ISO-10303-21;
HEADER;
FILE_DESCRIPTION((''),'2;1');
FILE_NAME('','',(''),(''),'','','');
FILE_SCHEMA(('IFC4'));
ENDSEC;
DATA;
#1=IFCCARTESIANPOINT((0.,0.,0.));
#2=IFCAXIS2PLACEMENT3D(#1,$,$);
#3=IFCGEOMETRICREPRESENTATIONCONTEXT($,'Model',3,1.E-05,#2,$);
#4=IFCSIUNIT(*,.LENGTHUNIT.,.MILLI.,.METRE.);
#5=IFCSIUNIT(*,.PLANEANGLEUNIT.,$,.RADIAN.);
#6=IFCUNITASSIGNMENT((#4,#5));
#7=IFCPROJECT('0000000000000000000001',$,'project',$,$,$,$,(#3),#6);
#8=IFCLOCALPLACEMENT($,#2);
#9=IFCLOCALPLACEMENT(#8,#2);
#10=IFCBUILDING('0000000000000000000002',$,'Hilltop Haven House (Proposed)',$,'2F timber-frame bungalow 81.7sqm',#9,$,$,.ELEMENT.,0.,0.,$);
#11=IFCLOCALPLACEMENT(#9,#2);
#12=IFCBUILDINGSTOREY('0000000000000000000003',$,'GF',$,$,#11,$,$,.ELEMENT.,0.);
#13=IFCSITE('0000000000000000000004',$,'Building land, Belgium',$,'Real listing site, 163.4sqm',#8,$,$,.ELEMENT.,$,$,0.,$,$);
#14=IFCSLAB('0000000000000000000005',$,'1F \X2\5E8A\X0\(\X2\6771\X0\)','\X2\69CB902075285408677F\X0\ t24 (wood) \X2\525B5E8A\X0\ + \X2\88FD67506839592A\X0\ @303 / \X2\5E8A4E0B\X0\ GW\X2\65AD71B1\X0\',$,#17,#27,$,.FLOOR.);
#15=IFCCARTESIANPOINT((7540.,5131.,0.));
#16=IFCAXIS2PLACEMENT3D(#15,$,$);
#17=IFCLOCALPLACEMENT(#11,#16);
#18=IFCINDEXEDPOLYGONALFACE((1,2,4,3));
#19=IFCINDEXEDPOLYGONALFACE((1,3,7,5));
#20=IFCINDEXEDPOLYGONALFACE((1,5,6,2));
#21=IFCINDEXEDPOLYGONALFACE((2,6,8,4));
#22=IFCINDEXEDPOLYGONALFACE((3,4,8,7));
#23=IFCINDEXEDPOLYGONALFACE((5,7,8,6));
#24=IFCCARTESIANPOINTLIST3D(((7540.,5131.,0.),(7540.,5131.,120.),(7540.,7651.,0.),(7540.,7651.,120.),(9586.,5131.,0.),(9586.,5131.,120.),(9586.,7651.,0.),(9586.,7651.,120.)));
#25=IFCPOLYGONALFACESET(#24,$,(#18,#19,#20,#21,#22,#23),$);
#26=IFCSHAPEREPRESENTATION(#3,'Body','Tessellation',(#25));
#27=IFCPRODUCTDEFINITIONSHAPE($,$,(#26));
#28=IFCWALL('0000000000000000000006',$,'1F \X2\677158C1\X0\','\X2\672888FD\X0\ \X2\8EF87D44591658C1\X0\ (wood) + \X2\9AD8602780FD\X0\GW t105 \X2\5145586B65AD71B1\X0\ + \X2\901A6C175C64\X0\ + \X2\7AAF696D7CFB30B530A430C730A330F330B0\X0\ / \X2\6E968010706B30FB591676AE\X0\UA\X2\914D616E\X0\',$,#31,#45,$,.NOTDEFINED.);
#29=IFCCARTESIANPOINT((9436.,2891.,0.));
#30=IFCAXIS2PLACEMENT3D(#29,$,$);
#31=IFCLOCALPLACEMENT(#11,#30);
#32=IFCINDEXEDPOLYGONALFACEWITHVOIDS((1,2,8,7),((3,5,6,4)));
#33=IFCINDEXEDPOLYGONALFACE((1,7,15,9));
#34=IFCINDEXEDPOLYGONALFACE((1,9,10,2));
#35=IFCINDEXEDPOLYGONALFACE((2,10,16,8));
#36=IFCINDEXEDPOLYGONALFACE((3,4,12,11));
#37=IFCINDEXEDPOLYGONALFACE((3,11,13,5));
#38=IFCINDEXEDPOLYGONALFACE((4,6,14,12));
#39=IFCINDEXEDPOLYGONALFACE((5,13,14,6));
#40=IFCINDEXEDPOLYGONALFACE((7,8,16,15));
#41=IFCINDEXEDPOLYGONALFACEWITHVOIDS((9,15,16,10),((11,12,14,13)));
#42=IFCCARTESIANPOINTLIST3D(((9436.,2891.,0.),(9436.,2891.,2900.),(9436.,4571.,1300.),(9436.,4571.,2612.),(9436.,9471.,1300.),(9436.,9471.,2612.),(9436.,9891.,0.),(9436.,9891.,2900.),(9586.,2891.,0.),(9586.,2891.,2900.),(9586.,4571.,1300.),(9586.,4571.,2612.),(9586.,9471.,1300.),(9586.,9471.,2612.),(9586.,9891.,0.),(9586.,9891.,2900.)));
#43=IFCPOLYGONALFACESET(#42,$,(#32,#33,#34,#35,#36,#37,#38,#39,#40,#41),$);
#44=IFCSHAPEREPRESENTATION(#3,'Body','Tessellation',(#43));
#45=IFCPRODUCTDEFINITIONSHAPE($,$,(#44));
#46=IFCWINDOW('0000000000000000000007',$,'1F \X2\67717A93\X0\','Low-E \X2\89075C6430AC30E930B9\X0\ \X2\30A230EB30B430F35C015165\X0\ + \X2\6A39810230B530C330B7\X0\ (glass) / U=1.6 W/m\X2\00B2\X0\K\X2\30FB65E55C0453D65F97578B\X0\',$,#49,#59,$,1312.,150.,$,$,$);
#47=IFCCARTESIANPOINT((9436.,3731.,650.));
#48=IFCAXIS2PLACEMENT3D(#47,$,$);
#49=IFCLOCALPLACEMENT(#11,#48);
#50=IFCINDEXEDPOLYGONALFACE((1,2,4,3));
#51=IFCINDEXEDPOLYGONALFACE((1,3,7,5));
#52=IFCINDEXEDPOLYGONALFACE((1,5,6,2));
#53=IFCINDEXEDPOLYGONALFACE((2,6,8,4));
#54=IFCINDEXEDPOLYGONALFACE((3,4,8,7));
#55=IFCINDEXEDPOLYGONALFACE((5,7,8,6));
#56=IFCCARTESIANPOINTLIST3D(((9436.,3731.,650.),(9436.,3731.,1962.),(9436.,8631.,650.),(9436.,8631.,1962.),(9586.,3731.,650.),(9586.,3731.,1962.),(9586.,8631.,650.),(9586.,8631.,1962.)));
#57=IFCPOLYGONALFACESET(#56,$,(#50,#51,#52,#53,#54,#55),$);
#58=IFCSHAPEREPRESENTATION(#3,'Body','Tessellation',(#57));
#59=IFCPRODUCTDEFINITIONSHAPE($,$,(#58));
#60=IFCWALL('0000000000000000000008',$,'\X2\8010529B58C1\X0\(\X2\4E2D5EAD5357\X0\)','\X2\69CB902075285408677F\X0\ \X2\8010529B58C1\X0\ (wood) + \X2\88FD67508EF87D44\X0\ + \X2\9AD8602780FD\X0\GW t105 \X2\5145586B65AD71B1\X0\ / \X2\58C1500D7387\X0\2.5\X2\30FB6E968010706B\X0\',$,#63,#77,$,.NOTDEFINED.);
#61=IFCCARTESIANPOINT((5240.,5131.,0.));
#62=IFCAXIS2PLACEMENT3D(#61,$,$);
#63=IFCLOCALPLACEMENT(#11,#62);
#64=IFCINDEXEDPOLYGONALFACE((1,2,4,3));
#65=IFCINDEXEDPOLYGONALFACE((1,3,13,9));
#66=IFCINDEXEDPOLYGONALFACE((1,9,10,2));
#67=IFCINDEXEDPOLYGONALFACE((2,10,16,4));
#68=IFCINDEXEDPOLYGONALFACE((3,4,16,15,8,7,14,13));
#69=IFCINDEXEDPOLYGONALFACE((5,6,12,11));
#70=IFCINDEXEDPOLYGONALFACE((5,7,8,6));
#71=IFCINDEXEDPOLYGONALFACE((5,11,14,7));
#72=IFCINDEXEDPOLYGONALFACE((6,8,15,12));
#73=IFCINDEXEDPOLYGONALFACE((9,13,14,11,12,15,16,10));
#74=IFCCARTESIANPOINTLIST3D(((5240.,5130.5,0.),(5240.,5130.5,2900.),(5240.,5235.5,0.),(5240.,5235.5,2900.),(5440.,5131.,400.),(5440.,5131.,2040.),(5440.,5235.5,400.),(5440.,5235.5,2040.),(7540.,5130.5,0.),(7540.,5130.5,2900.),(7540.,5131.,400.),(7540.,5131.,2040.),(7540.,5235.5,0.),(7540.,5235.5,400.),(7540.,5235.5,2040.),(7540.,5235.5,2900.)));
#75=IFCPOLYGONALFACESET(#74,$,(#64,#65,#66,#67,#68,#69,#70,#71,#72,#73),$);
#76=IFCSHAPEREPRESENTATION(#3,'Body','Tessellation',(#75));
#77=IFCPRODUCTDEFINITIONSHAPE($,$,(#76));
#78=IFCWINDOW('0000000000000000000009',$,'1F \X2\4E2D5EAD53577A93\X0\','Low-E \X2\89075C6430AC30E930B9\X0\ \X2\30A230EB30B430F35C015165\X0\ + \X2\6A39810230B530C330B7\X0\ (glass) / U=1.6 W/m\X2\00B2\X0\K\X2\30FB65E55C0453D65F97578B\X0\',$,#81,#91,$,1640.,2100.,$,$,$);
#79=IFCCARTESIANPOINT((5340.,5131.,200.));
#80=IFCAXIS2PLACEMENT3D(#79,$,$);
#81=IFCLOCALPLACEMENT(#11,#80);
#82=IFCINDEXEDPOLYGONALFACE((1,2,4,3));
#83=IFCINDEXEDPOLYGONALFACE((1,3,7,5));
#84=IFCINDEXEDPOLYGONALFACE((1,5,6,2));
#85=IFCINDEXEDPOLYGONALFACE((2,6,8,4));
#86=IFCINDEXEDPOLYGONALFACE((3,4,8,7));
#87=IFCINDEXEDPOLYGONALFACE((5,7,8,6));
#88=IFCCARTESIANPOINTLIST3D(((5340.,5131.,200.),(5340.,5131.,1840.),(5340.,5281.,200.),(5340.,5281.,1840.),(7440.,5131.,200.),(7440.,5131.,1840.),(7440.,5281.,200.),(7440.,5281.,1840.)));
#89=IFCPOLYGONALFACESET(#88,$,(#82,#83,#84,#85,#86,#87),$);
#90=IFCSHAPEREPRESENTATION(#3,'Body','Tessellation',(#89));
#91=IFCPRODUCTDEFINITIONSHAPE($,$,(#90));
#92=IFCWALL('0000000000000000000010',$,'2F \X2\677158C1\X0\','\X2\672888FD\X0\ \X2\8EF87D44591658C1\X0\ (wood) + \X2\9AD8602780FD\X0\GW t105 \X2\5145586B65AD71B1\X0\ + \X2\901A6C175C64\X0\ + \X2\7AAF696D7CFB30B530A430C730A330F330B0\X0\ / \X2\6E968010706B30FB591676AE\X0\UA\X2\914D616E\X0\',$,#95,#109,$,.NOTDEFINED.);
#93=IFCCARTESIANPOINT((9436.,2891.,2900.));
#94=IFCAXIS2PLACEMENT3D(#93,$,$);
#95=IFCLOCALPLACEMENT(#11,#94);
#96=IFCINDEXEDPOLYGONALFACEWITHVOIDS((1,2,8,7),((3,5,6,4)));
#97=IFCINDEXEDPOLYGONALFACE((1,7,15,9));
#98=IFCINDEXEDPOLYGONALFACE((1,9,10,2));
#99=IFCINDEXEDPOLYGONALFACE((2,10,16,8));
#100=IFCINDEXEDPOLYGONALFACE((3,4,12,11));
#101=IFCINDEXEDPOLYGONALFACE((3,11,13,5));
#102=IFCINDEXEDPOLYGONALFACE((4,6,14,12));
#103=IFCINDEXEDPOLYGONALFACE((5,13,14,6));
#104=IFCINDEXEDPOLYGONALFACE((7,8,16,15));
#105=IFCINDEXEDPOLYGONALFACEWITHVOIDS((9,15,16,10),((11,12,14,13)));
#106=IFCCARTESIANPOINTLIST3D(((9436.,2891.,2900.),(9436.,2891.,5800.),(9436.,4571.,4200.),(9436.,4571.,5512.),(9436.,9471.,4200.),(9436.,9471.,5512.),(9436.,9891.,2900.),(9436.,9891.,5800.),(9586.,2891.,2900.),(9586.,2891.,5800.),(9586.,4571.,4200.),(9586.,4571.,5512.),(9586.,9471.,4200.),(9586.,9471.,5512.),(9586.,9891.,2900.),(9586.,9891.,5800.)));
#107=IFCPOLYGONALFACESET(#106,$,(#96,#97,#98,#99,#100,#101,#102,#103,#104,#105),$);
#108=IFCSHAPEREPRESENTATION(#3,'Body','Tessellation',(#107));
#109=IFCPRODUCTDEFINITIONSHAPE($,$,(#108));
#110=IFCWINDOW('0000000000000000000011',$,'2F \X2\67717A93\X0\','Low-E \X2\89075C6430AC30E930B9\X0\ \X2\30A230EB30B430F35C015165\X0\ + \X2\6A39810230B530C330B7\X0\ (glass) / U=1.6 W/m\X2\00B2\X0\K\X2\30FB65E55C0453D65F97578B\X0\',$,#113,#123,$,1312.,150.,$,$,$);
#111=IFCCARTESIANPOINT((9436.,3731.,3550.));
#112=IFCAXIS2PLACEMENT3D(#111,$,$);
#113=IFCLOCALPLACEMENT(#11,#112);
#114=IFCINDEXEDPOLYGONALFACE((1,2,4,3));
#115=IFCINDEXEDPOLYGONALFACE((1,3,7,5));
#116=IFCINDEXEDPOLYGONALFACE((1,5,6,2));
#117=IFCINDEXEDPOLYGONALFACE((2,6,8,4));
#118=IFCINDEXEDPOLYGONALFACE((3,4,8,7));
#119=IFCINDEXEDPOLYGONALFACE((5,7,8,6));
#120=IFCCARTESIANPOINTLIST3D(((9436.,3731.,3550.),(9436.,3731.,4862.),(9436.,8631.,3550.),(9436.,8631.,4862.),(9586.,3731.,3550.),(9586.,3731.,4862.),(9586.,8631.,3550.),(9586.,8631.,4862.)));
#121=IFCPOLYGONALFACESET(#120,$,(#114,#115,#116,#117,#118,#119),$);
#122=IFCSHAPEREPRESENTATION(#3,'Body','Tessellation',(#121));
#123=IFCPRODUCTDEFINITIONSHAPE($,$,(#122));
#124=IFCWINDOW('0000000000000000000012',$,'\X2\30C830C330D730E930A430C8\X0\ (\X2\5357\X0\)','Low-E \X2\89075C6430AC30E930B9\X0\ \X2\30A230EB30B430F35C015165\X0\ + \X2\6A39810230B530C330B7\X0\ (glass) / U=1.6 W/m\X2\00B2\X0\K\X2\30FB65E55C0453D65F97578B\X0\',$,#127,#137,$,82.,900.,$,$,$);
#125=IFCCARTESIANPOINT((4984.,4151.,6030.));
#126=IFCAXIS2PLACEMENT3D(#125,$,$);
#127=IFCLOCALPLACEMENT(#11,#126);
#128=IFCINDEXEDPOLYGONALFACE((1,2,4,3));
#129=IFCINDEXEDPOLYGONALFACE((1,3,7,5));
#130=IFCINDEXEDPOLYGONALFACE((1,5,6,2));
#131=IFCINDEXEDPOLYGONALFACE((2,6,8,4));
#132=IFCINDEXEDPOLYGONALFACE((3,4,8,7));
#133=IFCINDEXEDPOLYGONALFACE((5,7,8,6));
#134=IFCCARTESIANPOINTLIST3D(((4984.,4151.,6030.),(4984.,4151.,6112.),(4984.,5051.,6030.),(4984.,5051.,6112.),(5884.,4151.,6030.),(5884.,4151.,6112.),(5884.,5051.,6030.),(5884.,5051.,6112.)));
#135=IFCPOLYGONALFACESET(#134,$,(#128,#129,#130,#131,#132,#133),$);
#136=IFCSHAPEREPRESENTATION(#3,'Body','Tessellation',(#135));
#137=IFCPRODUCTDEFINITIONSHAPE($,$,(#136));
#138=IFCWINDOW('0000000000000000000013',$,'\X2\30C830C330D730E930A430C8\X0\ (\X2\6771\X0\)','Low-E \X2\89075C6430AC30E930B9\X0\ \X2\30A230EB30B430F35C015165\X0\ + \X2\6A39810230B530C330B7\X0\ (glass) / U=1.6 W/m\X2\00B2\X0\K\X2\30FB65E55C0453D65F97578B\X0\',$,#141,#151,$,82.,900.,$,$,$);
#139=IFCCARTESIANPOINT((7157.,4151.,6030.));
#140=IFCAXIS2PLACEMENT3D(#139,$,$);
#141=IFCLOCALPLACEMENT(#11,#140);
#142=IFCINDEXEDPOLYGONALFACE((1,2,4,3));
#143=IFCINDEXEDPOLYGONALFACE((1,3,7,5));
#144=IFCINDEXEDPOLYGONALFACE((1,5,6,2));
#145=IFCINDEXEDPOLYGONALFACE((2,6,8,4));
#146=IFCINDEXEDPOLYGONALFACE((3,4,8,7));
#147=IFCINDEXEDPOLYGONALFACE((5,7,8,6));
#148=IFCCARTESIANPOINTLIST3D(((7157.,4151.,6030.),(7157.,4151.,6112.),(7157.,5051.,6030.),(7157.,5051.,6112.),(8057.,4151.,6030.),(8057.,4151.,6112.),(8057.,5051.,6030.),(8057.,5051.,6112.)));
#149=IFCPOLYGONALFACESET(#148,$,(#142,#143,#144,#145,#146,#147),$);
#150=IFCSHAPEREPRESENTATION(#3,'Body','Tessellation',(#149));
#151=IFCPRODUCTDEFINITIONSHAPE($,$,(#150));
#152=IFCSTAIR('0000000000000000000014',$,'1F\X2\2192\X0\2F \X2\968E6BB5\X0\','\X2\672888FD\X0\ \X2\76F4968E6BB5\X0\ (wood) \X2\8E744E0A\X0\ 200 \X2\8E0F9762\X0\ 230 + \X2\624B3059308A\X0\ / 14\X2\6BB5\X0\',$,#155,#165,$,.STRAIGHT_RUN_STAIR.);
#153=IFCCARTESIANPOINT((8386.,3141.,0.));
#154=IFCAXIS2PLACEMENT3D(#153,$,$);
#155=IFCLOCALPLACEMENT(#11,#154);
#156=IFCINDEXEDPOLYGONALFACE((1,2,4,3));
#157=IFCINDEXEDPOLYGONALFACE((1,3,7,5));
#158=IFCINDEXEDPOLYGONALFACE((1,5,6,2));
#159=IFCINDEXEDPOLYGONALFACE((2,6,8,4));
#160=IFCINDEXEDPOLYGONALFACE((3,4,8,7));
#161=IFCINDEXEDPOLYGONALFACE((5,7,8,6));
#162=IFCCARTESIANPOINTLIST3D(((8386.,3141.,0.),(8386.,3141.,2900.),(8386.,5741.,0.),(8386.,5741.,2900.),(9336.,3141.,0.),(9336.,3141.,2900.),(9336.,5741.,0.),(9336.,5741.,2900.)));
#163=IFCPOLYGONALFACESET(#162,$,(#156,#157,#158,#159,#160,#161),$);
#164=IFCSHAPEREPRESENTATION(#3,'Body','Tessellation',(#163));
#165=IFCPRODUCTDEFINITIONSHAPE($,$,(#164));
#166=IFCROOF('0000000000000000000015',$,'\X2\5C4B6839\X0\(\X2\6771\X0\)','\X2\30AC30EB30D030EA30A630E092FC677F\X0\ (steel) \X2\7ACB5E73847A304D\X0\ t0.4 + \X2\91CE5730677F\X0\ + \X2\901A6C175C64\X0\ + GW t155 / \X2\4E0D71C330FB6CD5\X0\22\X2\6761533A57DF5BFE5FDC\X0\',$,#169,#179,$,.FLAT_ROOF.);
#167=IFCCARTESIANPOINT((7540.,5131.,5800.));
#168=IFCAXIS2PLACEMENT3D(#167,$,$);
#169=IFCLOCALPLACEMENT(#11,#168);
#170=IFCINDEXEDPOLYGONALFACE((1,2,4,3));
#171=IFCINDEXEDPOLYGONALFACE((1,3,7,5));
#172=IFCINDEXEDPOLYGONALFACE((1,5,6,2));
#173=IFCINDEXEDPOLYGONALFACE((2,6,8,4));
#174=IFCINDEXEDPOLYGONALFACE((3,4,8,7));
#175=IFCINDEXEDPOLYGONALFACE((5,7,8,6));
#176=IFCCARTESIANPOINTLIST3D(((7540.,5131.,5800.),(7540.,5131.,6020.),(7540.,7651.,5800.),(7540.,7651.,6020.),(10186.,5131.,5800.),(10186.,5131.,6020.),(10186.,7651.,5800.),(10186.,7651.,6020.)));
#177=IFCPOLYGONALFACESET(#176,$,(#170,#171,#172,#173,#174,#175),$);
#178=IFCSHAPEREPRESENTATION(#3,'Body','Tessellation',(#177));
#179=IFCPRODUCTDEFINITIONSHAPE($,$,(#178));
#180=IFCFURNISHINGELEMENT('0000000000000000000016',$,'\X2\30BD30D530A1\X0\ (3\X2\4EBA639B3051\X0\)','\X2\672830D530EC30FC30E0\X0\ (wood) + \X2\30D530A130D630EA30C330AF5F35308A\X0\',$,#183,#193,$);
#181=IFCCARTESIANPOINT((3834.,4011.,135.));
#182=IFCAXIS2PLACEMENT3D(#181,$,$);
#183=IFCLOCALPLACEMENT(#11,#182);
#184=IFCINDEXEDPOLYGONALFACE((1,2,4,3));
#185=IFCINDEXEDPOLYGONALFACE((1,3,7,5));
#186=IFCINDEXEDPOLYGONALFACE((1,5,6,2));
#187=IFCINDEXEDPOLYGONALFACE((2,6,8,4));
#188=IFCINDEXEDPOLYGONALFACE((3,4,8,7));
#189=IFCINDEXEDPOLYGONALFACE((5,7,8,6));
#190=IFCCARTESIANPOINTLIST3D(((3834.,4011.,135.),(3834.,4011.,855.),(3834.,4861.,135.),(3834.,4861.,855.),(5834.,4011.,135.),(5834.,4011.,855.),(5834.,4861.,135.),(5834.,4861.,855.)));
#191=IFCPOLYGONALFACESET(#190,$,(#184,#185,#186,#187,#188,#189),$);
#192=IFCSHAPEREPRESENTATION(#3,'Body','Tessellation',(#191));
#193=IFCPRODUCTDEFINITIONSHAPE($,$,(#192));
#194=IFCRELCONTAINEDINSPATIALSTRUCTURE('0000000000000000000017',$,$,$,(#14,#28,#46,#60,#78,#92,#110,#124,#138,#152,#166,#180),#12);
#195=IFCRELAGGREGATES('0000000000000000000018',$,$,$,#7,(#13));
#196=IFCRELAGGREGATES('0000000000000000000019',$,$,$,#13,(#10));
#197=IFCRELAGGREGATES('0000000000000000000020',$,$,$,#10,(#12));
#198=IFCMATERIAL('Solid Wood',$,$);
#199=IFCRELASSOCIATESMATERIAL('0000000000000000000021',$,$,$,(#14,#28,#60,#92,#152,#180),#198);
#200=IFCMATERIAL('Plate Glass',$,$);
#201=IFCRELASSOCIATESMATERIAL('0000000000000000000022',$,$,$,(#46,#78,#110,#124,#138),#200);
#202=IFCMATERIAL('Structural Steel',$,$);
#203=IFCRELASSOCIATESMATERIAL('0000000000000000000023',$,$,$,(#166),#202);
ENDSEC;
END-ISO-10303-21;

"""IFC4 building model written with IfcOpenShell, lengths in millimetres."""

from ifc_helpers import new_model, si_unit, frame, frame_2d, origin, place, context, project, spatial, rectangle, extrude, material, element, fill, save


model = new_model("IFC4")

# Units and contexts
model_context = context("Model", 3, precision=1e-05, world=origin())
ifc_project = project(units=[si_unit("LENGTHUNIT", "METRE", prefix="MILLI"), si_unit("PLANEANGLEUNIT", "RADIAN")], contexts=[model_context])

# Site, building, storey
site_placement = place(None, origin())
site = spatial("IfcSite", under=ifc_project, at=site_placement, Name="Building land, Belgium", ObjectType="Real listing site, 163.4sqm", CompositionType="ELEMENT", RefElevation=0.0)
building_placement = place(site_placement, origin())
building = spatial("IfcBuilding", under=site, at=building_placement, Name="Hilltop Haven House (Proposed)", ObjectType="2F timber-frame bungalow 81.7sqm", CompositionType="ELEMENT", ElevationOfRefHeight=0.0, ElevationOfTerrain=0.0)
storey_placement = place(building_placement, origin())
storey = spatial("IfcBuildingStorey", under=building, at=storey_placement, Name="GF", CompositionType="ELEMENT", Elevation=0.0)

# Slab
ifc_material_1 = material(Name="Solid Wood")
slab_placement = place(storey_placement, frame((7540.0, 5131.0, 0.0)))
element("IfcSlab", 1, at=slab_placement, inside=storey, material=ifc_material_1, Name="1F 床(東)", Description="構造用合板 t24 (wood) 剛床 + 製材根太 @303 / 床下 GW断熱", PredefinedType="FLOOR", context=model_context, shape_type="SweptSolid", body=[
    extrude(rectangle(XDim=2046.0, YDim=2520.0, at=frame_2d((1023.0, 1260.0))), frame((7540.0, 5131.0, 0.0)), (0.0, 0.0, 1.0), 120.0),
])

# Walls, openings, windows
wall_1_placement = place(storey_placement, frame((9436.0, 2891.0, 0.0)))
wall_1 = element("IfcWall", 2, at=wall_1_placement, inside=storey, material=ifc_material_1, Name="1F 東壁", Description="木製 軸組外壁 (wood) + 高性能GW t105 充填断熱 + 通気層 + 窯業系サイディング / 準耐火・外皮UA配慮", PredefinedType="NOTDEFINED", context=model_context, shape_type="SweptSolid", body=[
    extrude(rectangle(XDim=150.0, YDim=7000.0, at=frame_2d((75.0, 3500.0))), frame((9436.0, 2891.0, 0.0)), (0.0, 0.0, 1.0), 2900.0),
])
opening_1_placement = place(storey_placement, frame((9436.0, 3731.0, 650.0)))
opening_1 = element("IfcOpeningElement", 3, at=opening_1_placement, cuts=wall_1, PredefinedType="NOTDEFINED", context=model_context, shape_type="SweptSolid", body=[
    extrude(rectangle(XDim=150.0, YDim=4900.0, at=frame_2d((75.0, 2450.0))), frame((9436.0, 3731.0, 650.0)), (0.0, 0.0, 1.0), 1312.0),
])
ifc_material_2 = material(Name="Plate Glass")
window_1_placement = place(storey_placement, frame((9436.0, 3731.0, 650.0)))
window_1 = element("IfcWindow", 4, at=window_1_placement, inside=storey, material=ifc_material_2, Name="1F 東窓", Description="Low-E 複層ガラス アルゴン封入 + 樹脂サッシ (glass) / U=1.6 W/m²K・日射取得型", OverallHeight=1312.0, OverallWidth=150.0, context=model_context, shape_type="SweptSolid", body=[
    extrude(rectangle(XDim=150.0, YDim=4900.0, at=frame_2d((75.0, 2450.0))), frame((9436.0, 3731.0, 650.0)), (0.0, 0.0, 1.0), 1312.0),
])
fill(opening_1, window_1)
wall_2_placement = place(storey_placement, frame((5240.0, 5131.0, 0.0)))
wall_2 = element("IfcWall", 5, at=wall_2_placement, inside=storey, material=ifc_material_1, Name="耐力壁(中庭南)", Description="構造用合板 耐力壁 (wood) + 製材軸組 + 高性能GW t105 充填断熱 / 壁倍率2.5・準耐火", PredefinedType="NOTDEFINED", context=model_context, shape_type="SweptSolid", body=[
    extrude(rectangle(XDim=2300.0, YDim=105.0, at=frame_2d((1150.0, 52.0))), frame((5240.0, 5131.0, 0.0)), (0.0, 0.0, 1.0), 2900.0),
])
opening_2_placement = place(storey_placement, frame((5340.0, 5131.0, 200.0)))
opening_2 = element("IfcOpeningElement", 6, at=opening_2_placement, cuts=wall_2, PredefinedType="NOTDEFINED", context=model_context, shape_type="SweptSolid", body=[
    extrude(rectangle(XDim=2100.0, YDim=150.0, at=frame_2d((1050.0, 75.0))), frame((5340.0, 5131.0, 200.0)), (0.0, 0.0, 1.0), 1640.0),
])
window_2_placement = place(storey_placement, frame((5340.0, 5131.0, 200.0)))
window_2 = element("IfcWindow", 7, at=window_2_placement, inside=storey, material=ifc_material_2, Name="1F 中庭南窓", Description="Low-E 複層ガラス アルゴン封入 + 樹脂サッシ (glass) / U=1.6 W/m²K・日射取得型", OverallHeight=1640.0, OverallWidth=2100.0, context=model_context, shape_type="SweptSolid", body=[
    extrude(rectangle(XDim=2100.0, YDim=150.0, at=frame_2d((1050.0, 75.0))), frame((5340.0, 5131.0, 200.0)), (0.0, 0.0, 1.0), 1640.0),
])
fill(opening_2, window_2)

# Wall, opening, window
wall_3_placement = place(storey_placement, frame((9436.0, 2891.0, 2900.0)))
wall_3 = element("IfcWall", 8, at=wall_3_placement, inside=storey, material=ifc_material_1, Name="2F 東壁", Description="木製 軸組外壁 (wood) + 高性能GW t105 充填断熱 + 通気層 + 窯業系サイディング / 準耐火・外皮UA配慮", PredefinedType="NOTDEFINED", context=model_context, shape_type="SweptSolid", body=[
    extrude(rectangle(XDim=150.0, YDim=7000.0, at=frame_2d((75.0, 3500.0))), frame((9436.0, 2891.0, 2900.0)), (0.0, 0.0, 1.0), 2900.0),
])
opening_3_placement = place(storey_placement, frame((9436.0, 3731.0, 3550.0)))
opening_3 = element("IfcOpeningElement", 9, at=opening_3_placement, cuts=wall_3, PredefinedType="NOTDEFINED", context=model_context, shape_type="SweptSolid", body=[
    extrude(rectangle(XDim=150.0, YDim=4900.0, at=frame_2d((75.0, 2450.0))), frame((9436.0, 3731.0, 3550.0)), (0.0, 0.0, 1.0), 1312.0),
])
window_3_placement = place(storey_placement, frame((9436.0, 3731.0, 3550.0)))
window_3 = element("IfcWindow", 10, at=window_3_placement, inside=storey, material=ifc_material_2, Name="2F 東窓", Description="Low-E 複層ガラス アルゴン封入 + 樹脂サッシ (glass) / U=1.6 W/m²K・日射取得型", OverallHeight=1312.0, OverallWidth=150.0, context=model_context, shape_type="SweptSolid", body=[
    extrude(rectangle(XDim=150.0, YDim=4900.0, at=frame_2d((75.0, 2450.0))), frame((9436.0, 3731.0, 3550.0)), (0.0, 0.0, 1.0), 1312.0),
])
fill(opening_3, window_3)

# Windows
window_4_placement = place(storey_placement, frame((4984.0, 4151.0, 6030.0)))
element("IfcWindow", 11, at=window_4_placement, inside=storey, material=ifc_material_2, Name="トップライト (南)", Description="Low-E 複層ガラス アルゴン封入 + 樹脂サッシ (glass) / U=1.6 W/m²K・日射取得型", OverallHeight=82.0, OverallWidth=900.0, context=model_context, shape_type="SweptSolid", body=[
    extrude(rectangle(XDim=900.0, YDim=900.0, at=frame_2d((450.0, 450.0))), frame((4984.0, 4151.0, 6030.0)), (0.0, 0.0, 1.0), 82.0),
])
window_5_placement = place(storey_placement, frame((7157.0, 4151.0, 6030.0)))
element("IfcWindow", 12, at=window_5_placement, inside=storey, material=ifc_material_2, Name="トップライト (東)", Description="Low-E 複層ガラス アルゴン封入 + 樹脂サッシ (glass) / U=1.6 W/m²K・日射取得型", OverallHeight=82.0, OverallWidth=900.0, context=model_context, shape_type="SweptSolid", body=[
    extrude(rectangle(XDim=900.0, YDim=900.0, at=frame_2d((450.0, 450.0))), frame((7157.0, 4151.0, 6030.0)), (0.0, 0.0, 1.0), 82.0),
])

# Stair
stair_placement = place(storey_placement, frame((8386.0, 3141.0, 0.0)))
element("IfcStair", 13, at=stair_placement, inside=storey, material=ifc_material_1, Name="1F→2F 階段", Description="木製 直階段 (wood) 蹴上 200 踏面 230 + 手すり / 14段", PredefinedType="STRAIGHT_RUN_STAIR", context=model_context, shape_type="SweptSolid", body=[
    extrude(rectangle(XDim=950.0, YDim=2600.0, at=frame_2d((475.0, 1300.0))), frame((8386.0, 3141.0, 0.0)), (0.0, 0.0, 1.0), 2900.0),
])

# Roof
ifc_material_3 = material(Name="Structural Steel")
roof_placement = place(storey_placement, frame((7540.0, 5131.0, 5800.0)))
element("IfcRoof", 14, at=roof_placement, inside=storey, material=ifc_material_3, Name="屋根(東)", Description="ガルバリウム鋼板 (steel) 立平葺き t0.4 + 野地板 + 通気層 + GW t155 / 不燃・法22条区域対応", PredefinedType="FLAT_ROOF", context=model_context, shape_type="SweptSolid", body=[
    extrude(rectangle(XDim=2646.0, YDim=2520.0, at=frame_2d((1323.0, 1260.0))), frame((7540.0, 5131.0, 5800.0)), (0.0, 0.0, 1.0), 220.0),
])

# Furnishing element
furnishing_1_placement = place(storey_placement, frame((3834.0, 4011.0, 135.0)))
element("IfcFurnishingElement", 15, at=furnishing_1_placement, inside=storey, material=ifc_material_1, Name="ソファ (3人掛け)", Description="木フレーム (wood) + ファブリック張り", context=model_context, shape_type="SweptSolid", body=[
    extrude(rectangle(XDim=2000.0, YDim=850.0, at=frame_2d((1000.0, 425.0))), frame((3834.0, 4011.0, 135.0)), (0.0, 0.0, 1.0), 720.0),
])

save(model, "model.ifc")
